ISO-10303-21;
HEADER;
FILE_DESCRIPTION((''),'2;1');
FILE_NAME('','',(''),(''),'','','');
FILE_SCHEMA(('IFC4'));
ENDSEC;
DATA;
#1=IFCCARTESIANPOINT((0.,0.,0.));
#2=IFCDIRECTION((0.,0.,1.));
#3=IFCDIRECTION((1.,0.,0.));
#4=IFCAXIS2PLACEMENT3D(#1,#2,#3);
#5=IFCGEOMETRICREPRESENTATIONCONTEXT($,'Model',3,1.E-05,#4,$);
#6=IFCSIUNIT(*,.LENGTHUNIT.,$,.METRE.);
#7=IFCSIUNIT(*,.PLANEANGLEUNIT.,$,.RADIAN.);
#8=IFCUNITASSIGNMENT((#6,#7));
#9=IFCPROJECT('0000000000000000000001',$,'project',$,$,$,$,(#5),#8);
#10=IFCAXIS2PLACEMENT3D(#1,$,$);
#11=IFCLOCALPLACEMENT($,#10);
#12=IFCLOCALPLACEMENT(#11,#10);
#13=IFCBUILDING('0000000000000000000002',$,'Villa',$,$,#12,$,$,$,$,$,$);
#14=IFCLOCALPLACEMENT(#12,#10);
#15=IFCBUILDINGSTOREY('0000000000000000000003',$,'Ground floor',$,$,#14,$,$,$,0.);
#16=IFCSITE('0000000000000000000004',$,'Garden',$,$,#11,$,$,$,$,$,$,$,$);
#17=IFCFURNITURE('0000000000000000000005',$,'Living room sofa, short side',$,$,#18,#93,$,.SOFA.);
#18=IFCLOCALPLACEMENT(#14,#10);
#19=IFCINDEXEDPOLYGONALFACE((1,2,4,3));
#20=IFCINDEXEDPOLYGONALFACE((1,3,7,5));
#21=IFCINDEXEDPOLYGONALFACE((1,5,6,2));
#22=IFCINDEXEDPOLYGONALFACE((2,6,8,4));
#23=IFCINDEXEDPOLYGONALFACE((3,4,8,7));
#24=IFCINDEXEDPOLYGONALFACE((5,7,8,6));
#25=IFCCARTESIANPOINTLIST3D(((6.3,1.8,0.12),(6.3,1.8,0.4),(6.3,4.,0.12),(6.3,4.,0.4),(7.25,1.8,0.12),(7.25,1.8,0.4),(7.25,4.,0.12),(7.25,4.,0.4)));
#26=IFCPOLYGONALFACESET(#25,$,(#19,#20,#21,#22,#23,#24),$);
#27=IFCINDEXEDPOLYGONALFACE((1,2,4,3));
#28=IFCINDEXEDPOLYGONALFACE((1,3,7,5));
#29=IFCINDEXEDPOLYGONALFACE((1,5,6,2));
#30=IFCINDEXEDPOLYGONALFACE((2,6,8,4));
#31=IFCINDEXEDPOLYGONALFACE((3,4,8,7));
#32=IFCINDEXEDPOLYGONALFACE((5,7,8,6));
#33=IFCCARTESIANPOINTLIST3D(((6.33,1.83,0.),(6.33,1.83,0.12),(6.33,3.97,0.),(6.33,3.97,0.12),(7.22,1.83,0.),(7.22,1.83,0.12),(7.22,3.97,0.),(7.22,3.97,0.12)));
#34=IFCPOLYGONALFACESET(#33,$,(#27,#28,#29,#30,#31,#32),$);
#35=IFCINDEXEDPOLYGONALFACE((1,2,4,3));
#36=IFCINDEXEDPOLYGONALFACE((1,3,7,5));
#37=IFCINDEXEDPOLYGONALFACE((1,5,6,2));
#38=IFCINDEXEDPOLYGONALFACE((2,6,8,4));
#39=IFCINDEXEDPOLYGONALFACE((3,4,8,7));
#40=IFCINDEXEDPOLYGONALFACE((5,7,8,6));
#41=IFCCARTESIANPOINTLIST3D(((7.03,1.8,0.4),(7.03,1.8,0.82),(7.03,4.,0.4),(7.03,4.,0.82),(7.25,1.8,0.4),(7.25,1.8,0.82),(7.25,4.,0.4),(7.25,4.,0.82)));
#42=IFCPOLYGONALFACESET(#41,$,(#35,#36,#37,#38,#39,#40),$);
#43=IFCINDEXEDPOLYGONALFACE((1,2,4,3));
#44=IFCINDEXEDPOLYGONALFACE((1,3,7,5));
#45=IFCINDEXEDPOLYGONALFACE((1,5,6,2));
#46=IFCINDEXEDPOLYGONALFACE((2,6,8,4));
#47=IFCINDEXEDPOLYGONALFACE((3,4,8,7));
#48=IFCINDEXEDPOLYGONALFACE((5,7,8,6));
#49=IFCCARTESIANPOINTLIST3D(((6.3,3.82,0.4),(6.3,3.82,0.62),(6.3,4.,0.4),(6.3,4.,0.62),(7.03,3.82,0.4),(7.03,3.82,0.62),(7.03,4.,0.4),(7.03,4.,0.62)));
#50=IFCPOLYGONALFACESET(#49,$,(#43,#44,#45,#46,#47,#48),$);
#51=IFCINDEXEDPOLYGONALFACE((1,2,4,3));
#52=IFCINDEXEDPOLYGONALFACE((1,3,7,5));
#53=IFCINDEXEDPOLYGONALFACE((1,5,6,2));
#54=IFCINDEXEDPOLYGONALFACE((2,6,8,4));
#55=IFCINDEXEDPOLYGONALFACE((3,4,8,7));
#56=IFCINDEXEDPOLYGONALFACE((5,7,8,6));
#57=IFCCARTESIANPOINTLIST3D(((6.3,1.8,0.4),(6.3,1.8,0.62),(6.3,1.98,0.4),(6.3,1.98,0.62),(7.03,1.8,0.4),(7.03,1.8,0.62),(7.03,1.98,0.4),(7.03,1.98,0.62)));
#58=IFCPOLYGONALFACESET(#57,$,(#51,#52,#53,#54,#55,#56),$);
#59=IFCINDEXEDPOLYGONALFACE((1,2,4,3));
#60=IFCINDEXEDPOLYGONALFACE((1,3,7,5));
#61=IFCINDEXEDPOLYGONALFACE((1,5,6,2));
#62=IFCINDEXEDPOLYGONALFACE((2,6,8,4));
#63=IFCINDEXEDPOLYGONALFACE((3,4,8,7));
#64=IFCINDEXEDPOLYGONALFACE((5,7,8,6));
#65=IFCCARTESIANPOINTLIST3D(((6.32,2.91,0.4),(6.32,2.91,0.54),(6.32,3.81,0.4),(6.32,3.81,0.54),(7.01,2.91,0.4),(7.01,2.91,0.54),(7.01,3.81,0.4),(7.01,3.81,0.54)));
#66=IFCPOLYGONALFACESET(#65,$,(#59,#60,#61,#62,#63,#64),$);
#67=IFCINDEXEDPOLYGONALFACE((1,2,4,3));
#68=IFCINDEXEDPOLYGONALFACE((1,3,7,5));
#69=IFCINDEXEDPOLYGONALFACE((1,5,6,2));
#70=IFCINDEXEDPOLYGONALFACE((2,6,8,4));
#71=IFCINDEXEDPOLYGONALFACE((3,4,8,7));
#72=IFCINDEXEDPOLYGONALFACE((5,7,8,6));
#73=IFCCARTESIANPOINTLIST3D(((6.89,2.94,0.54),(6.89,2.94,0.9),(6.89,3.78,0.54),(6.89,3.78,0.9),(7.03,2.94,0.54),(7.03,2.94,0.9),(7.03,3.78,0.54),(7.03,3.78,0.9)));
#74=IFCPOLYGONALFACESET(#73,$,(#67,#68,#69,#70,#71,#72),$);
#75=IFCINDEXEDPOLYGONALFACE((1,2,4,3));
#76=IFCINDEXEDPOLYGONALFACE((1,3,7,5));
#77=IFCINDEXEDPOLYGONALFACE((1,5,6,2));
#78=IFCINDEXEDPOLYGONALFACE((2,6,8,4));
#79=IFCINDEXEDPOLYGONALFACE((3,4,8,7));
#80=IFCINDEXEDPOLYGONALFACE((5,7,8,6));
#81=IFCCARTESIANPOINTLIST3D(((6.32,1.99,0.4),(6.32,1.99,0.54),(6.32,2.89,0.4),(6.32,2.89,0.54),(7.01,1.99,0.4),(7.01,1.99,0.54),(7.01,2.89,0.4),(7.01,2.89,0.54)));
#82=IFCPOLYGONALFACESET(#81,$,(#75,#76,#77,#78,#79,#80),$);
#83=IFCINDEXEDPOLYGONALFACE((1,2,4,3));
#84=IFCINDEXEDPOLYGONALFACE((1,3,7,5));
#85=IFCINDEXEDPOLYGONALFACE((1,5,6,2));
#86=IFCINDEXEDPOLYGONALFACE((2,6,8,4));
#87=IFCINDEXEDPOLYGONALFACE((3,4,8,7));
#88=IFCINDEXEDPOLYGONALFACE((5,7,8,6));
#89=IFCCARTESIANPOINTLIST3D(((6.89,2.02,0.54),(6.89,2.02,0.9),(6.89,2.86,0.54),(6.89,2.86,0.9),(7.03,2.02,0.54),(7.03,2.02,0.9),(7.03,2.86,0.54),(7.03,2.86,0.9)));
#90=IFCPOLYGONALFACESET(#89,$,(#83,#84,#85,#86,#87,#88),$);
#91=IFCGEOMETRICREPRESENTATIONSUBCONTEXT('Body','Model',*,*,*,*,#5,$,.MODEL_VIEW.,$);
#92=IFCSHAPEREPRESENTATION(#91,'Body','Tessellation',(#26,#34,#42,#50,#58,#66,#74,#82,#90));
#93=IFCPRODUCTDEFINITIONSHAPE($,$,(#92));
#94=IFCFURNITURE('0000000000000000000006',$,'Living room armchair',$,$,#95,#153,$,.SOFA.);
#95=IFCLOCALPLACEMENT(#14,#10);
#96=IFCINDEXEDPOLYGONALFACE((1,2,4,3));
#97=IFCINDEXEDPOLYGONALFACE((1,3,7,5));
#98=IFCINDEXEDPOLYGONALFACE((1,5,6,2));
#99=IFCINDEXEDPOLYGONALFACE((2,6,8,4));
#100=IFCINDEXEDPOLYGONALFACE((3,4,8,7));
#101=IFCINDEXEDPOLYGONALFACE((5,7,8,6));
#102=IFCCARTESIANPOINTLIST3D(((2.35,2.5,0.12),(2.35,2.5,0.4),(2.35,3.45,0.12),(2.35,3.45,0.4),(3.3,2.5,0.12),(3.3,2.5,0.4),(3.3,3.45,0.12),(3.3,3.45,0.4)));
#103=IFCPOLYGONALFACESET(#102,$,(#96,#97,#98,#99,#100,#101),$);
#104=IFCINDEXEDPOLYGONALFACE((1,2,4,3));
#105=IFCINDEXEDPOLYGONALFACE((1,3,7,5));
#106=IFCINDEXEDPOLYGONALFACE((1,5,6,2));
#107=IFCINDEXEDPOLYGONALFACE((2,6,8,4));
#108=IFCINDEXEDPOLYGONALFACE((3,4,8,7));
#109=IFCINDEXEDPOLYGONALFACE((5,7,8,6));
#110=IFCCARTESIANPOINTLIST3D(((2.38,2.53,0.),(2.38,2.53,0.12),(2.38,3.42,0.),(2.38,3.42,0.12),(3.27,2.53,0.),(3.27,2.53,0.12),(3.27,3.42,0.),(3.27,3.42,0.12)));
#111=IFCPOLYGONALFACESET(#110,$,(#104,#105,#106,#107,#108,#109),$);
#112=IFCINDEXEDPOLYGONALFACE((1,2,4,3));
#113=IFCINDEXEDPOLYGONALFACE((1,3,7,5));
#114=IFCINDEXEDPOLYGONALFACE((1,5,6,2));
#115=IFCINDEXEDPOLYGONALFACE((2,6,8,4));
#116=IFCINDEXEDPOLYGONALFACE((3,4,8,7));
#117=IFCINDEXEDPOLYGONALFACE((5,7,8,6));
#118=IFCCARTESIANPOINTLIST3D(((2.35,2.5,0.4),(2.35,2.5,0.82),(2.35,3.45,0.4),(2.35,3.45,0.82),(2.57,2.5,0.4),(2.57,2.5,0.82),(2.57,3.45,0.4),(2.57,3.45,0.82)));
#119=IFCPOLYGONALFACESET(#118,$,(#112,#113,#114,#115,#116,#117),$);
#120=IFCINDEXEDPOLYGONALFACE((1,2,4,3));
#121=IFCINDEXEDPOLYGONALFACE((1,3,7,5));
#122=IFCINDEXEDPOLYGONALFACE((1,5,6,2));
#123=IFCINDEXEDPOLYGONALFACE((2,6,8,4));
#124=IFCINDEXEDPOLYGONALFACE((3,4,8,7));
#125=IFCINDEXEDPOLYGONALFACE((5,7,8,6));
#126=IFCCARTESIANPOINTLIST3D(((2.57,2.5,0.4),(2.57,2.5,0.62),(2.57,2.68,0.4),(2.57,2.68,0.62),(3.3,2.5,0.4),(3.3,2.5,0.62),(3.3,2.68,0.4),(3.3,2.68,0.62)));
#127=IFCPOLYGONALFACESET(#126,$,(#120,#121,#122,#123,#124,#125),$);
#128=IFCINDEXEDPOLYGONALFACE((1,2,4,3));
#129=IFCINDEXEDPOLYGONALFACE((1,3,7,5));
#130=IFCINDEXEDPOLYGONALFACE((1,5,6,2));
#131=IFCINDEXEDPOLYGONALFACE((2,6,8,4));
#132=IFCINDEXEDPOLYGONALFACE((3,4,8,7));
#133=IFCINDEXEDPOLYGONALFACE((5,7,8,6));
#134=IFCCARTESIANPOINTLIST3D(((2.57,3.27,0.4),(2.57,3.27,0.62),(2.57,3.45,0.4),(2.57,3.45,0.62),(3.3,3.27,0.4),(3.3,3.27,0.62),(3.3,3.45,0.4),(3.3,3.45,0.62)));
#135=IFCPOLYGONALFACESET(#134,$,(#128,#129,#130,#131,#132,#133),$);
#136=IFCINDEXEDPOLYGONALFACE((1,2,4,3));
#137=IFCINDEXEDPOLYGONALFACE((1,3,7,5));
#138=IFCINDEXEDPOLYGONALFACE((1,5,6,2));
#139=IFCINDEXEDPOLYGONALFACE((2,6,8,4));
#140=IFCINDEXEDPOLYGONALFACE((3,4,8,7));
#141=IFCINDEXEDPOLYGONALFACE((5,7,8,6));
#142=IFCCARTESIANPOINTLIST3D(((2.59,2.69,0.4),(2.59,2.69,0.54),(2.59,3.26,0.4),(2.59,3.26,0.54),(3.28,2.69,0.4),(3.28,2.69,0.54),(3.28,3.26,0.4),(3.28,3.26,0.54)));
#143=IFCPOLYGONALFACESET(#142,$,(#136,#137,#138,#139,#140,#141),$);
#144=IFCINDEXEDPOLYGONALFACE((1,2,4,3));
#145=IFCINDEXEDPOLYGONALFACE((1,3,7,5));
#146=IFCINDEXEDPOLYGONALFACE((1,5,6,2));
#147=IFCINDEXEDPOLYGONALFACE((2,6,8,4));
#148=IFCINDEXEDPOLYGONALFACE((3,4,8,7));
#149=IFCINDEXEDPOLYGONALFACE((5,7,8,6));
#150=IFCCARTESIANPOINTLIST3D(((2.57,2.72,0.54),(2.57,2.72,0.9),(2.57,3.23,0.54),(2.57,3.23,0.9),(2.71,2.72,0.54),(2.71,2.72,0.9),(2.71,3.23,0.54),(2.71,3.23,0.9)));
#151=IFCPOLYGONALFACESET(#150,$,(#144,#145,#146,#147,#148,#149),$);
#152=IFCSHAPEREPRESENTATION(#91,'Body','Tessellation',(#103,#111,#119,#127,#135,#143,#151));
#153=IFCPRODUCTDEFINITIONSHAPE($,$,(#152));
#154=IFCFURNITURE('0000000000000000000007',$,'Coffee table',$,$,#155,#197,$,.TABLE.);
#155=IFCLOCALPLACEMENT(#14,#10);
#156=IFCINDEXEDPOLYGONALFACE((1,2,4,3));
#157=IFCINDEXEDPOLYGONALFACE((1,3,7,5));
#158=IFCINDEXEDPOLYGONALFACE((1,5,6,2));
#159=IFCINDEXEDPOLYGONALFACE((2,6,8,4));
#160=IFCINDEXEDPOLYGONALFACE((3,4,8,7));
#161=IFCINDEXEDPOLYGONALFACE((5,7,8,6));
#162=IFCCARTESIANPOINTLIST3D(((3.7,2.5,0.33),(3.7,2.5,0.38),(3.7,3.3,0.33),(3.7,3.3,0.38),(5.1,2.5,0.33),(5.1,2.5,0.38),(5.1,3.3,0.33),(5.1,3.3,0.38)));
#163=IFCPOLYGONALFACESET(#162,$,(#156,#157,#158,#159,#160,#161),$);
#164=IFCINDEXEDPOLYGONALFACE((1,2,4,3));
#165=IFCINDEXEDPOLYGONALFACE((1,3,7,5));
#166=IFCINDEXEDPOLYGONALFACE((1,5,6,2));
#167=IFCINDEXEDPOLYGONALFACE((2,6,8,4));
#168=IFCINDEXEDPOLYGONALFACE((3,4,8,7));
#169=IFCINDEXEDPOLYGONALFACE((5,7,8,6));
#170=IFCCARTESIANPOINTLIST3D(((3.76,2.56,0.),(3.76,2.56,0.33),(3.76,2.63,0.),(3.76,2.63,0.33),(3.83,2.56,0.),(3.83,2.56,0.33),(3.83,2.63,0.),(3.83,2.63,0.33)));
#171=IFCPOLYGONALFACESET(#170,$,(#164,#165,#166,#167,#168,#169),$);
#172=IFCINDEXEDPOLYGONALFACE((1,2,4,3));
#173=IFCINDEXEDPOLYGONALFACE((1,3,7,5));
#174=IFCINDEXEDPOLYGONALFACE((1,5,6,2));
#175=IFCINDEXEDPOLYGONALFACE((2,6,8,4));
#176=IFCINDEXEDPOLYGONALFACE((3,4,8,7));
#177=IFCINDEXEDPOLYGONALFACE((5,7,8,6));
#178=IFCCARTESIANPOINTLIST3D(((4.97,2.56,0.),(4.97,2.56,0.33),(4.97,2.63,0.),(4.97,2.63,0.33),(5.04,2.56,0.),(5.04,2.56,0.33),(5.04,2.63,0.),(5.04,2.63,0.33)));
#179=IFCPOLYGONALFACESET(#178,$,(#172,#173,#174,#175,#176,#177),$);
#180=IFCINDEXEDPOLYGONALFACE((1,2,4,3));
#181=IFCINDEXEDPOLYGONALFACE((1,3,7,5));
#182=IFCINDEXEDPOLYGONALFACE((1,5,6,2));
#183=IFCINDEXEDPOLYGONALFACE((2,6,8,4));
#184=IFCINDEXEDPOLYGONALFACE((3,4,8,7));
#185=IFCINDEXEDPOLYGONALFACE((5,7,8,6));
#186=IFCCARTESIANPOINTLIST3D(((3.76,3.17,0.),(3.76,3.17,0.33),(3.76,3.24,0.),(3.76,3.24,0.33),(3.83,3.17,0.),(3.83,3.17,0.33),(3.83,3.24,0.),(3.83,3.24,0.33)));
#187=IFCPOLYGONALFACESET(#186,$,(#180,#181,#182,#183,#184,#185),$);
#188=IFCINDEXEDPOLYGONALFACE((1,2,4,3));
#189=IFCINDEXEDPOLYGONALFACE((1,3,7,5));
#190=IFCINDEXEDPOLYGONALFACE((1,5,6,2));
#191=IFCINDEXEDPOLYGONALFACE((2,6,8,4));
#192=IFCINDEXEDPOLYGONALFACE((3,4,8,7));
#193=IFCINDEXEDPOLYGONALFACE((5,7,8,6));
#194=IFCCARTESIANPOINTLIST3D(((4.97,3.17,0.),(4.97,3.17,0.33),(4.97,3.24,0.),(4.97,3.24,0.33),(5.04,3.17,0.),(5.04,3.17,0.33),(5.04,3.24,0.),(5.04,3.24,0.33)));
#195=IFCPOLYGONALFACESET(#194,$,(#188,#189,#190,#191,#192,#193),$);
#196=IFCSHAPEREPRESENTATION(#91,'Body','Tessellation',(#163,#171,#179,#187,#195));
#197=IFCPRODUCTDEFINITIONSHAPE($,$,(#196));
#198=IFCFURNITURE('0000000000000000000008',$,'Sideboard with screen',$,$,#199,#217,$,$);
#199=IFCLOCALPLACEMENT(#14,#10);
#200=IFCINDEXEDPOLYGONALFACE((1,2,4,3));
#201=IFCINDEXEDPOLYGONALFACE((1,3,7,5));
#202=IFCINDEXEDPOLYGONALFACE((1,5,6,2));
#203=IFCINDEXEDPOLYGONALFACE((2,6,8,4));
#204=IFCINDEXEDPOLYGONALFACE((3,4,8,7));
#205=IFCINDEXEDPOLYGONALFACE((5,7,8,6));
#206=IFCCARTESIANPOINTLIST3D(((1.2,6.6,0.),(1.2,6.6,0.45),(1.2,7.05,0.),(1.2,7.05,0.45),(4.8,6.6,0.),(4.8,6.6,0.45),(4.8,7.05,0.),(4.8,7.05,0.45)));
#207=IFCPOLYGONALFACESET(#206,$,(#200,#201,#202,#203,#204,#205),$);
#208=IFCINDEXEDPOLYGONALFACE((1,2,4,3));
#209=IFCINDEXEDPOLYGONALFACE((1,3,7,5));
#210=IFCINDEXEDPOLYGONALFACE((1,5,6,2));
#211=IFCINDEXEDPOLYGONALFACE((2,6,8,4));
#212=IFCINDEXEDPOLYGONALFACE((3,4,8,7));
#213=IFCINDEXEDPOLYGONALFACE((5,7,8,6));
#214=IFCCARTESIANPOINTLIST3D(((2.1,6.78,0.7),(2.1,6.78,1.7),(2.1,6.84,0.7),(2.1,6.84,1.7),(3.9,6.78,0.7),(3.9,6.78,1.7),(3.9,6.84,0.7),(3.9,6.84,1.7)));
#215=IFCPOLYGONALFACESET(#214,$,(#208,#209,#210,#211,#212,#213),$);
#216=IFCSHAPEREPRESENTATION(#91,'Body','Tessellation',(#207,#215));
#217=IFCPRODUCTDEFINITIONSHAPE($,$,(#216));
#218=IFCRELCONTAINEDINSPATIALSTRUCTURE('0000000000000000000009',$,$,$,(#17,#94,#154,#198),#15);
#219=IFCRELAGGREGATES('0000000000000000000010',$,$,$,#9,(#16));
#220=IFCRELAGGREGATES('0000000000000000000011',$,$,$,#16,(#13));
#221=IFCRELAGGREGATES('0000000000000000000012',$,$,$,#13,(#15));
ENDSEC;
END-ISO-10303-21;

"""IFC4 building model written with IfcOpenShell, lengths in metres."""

from ifc_helpers import new_model, si_unit, frame, frame_2d, origin, origin_with_axes, place, context, subcontext, project, spatial, rectangle, extrude, element, save


model = new_model("IFC4")

# Units and contexts
model_context = context("Model", 3, precision=1e-05, world=origin_with_axes())
body_context = subcontext(model_context, "Body", "Model", "MODEL_VIEW")
ifc_project = project(units=[si_unit("LENGTHUNIT", "METRE"), si_unit("PLANEANGLEUNIT", "RADIAN")], contexts=[model_context])

# Site, building, storey
site_placement = place(None, origin())
site = spatial("IfcSite", under=ifc_project, at=site_placement, Name="Garden")
building_placement = place(site_placement, origin())
building = spatial("IfcBuilding", under=site, at=building_placement, Name="Villa")
storey_placement = place(building_placement, origin())
storey = spatial("IfcBuildingStorey", under=building, at=storey_placement, Name="Ground floor", Elevation=0.0)

# Furniture
furniture_1_placement = place(storey_placement, frame((6.3, 4.0, 0.0), x_axis=(0.0, -1.0, 0.0)))
element("IfcFurniture", 1, at=furniture_1_placement, inside=storey, Name="Living room sofa, short side", PredefinedType="SOFA", context=body_context, shape_type="SweptSolid", body=[
    extrude(rectangle(XDim=2.2, YDim=0.95, at=frame_2d((1.1, 0.475))), frame((0.0, 0.0, 0.12)), (0.0, 0.0, 1.0), 0.28),
    extrude(rectangle(XDim=2.14, YDim=0.89, at=frame_2d((1.07, 0.445))), frame((0.03, 0.03, 0.0)), (0.0, 0.0, 1.0), 0.12),
    extrude(rectangle(XDim=2.2, YDim=0.22, at=frame_2d((1.1, 0.11))), frame((0.0, 0.73, 0.4)), (0.0, 0.0, 1.0), 0.42),
    extrude(rectangle(XDim=0.18, YDim=0.73, at=frame_2d((0.09, 0.365))), frame((0.0, 0.0, 0.4)), (0.0, 0.0, 1.0), 0.22),
    extrude(rectangle(XDim=0.18, YDim=0.73, at=frame_2d((0.09, 0.365))), frame((2.02, 0.0, 0.4)), (0.0, 0.0, 1.0), 0.22),
    extrude(rectangle(XDim=0.9, YDim=0.69, at=frame_2d((0.45, 0.345))), frame((0.19, 0.02, 0.4)), (0.0, 0.0, 1.0), 0.14),
    extrude(rectangle(XDim=0.84, YDim=0.14, at=frame_2d((0.42, 0.07))), frame((0.22, 0.59, 0.54)), (0.0, 0.0, 1.0), 0.36),
    extrude(rectangle(XDim=0.9, YDim=0.69, at=frame_2d((0.45, 0.345))), frame((1.11, 0.02, 0.4)), (0.0, 0.0, 1.0), 0.14),
    extrude(rectangle(XDim=0.84, YDim=0.14, at=frame_2d((0.42, 0.07))), frame((1.14, 0.59, 0.54)), (0.0, 0.0, 1.0), 0.36),
])
furniture_2_placement = place(storey_placement, frame((3.3, 2.5, 0.0), x_axis=(0.0, 1.0, 0.0)))
element("IfcFurniture", 2, at=furniture_2_placement, inside=storey, Name="Living room armchair", PredefinedType="SOFA", context=body_context, shape_type="SweptSolid", body=[
    extrude(rectangle(XDim=0.95, YDim=0.95, at=frame_2d((0.475, 0.475))), frame((0.0, 0.0, 0.12)), (0.0, 0.0, 1.0), 0.28),
    extrude(rectangle(XDim=0.89, YDim=0.89, at=frame_2d((0.445, 0.445))), frame((0.03, 0.03, 0.0)), (0.0, 0.0, 1.0), 0.12),
    extrude(rectangle(XDim=0.95, YDim=0.22, at=frame_2d((0.475, 0.11))), frame((0.0, 0.73, 0.4)), (0.0, 0.0, 1.0), 0.42),
    extrude(rectangle(XDim=0.18, YDim=0.73, at=frame_2d((0.09, 0.365))), frame((0.0, 0.0, 0.4)), (0.0, 0.0, 1.0), 0.22),
    extrude(rectangle(XDim=0.18, YDim=0.73, at=frame_2d((0.09, 0.365))), frame((0.77, 0.0, 0.4)), (0.0, 0.0, 1.0), 0.22),
    extrude(rectangle(XDim=0.57, YDim=0.69, at=frame_2d((0.285, 0.345))), frame((0.19, 0.02, 0.4)), (0.0, 0.0, 1.0), 0.14),
    extrude(rectangle(XDim=0.51, YDim=0.14, at=frame_2d((0.255, 0.07))), frame((0.22, 0.59, 0.54)), (0.0, 0.0, 1.0), 0.36),
])
furniture_3_placement = place(storey_placement, frame((3.7, 2.5, 0.0)))
element("IfcFurniture", 3, at=furniture_3_placement, inside=storey, Name="Coffee table", PredefinedType="TABLE", context=body_context, shape_type="SweptSolid", body=[
    extrude(rectangle(XDim=1.4, YDim=0.8, at=frame_2d((0.7, 0.4))), frame((0.0, 0.0, 0.33)), (0.0, 0.0, 1.0), 0.05),
    extrude(rectangle(XDim=0.07, YDim=0.07, at=frame_2d((0.035, 0.035))), frame((0.06, 0.06, 0.0)), (0.0, 0.0, 1.0), 0.33),
    extrude(rectangle(XDim=0.07, YDim=0.07, at=frame_2d((0.035, 0.035))), frame((1.27, 0.06, 0.0)), (0.0, 0.0, 1.0), 0.33),
    extrude(rectangle(XDim=0.07, YDim=0.07, at=frame_2d((0.035, 0.035))), frame((0.06, 0.67, 0.0)), (0.0, 0.0, 1.0), 0.33),
    extrude(rectangle(XDim=0.07, YDim=0.07, at=frame_2d((0.035, 0.035))), frame((1.27, 0.67, 0.0)), (0.0, 0.0, 1.0), 0.33),
])
furniture_4_placement = place(storey_placement, frame((1.2, 6.6, 0.0)))
element("IfcFurniture", 4, at=furniture_4_placement, inside=storey, Name="Sideboard with screen", context=body_context, shape_type="SweptSolid", body=[
    extrude(rectangle(XDim=3.6, YDim=0.45, at=frame_2d((1.8, 0.225))), origin(), (0.0, 0.0, 1.0), 0.45),
    extrude(rectangle(XDim=1.8, YDim=0.06, at=frame_2d((0.9, 0.03))), frame((0.9, 0.18, 0.7)), (0.0, 0.0, 1.0), 1.0),
])

save(model, "model.ifc")
